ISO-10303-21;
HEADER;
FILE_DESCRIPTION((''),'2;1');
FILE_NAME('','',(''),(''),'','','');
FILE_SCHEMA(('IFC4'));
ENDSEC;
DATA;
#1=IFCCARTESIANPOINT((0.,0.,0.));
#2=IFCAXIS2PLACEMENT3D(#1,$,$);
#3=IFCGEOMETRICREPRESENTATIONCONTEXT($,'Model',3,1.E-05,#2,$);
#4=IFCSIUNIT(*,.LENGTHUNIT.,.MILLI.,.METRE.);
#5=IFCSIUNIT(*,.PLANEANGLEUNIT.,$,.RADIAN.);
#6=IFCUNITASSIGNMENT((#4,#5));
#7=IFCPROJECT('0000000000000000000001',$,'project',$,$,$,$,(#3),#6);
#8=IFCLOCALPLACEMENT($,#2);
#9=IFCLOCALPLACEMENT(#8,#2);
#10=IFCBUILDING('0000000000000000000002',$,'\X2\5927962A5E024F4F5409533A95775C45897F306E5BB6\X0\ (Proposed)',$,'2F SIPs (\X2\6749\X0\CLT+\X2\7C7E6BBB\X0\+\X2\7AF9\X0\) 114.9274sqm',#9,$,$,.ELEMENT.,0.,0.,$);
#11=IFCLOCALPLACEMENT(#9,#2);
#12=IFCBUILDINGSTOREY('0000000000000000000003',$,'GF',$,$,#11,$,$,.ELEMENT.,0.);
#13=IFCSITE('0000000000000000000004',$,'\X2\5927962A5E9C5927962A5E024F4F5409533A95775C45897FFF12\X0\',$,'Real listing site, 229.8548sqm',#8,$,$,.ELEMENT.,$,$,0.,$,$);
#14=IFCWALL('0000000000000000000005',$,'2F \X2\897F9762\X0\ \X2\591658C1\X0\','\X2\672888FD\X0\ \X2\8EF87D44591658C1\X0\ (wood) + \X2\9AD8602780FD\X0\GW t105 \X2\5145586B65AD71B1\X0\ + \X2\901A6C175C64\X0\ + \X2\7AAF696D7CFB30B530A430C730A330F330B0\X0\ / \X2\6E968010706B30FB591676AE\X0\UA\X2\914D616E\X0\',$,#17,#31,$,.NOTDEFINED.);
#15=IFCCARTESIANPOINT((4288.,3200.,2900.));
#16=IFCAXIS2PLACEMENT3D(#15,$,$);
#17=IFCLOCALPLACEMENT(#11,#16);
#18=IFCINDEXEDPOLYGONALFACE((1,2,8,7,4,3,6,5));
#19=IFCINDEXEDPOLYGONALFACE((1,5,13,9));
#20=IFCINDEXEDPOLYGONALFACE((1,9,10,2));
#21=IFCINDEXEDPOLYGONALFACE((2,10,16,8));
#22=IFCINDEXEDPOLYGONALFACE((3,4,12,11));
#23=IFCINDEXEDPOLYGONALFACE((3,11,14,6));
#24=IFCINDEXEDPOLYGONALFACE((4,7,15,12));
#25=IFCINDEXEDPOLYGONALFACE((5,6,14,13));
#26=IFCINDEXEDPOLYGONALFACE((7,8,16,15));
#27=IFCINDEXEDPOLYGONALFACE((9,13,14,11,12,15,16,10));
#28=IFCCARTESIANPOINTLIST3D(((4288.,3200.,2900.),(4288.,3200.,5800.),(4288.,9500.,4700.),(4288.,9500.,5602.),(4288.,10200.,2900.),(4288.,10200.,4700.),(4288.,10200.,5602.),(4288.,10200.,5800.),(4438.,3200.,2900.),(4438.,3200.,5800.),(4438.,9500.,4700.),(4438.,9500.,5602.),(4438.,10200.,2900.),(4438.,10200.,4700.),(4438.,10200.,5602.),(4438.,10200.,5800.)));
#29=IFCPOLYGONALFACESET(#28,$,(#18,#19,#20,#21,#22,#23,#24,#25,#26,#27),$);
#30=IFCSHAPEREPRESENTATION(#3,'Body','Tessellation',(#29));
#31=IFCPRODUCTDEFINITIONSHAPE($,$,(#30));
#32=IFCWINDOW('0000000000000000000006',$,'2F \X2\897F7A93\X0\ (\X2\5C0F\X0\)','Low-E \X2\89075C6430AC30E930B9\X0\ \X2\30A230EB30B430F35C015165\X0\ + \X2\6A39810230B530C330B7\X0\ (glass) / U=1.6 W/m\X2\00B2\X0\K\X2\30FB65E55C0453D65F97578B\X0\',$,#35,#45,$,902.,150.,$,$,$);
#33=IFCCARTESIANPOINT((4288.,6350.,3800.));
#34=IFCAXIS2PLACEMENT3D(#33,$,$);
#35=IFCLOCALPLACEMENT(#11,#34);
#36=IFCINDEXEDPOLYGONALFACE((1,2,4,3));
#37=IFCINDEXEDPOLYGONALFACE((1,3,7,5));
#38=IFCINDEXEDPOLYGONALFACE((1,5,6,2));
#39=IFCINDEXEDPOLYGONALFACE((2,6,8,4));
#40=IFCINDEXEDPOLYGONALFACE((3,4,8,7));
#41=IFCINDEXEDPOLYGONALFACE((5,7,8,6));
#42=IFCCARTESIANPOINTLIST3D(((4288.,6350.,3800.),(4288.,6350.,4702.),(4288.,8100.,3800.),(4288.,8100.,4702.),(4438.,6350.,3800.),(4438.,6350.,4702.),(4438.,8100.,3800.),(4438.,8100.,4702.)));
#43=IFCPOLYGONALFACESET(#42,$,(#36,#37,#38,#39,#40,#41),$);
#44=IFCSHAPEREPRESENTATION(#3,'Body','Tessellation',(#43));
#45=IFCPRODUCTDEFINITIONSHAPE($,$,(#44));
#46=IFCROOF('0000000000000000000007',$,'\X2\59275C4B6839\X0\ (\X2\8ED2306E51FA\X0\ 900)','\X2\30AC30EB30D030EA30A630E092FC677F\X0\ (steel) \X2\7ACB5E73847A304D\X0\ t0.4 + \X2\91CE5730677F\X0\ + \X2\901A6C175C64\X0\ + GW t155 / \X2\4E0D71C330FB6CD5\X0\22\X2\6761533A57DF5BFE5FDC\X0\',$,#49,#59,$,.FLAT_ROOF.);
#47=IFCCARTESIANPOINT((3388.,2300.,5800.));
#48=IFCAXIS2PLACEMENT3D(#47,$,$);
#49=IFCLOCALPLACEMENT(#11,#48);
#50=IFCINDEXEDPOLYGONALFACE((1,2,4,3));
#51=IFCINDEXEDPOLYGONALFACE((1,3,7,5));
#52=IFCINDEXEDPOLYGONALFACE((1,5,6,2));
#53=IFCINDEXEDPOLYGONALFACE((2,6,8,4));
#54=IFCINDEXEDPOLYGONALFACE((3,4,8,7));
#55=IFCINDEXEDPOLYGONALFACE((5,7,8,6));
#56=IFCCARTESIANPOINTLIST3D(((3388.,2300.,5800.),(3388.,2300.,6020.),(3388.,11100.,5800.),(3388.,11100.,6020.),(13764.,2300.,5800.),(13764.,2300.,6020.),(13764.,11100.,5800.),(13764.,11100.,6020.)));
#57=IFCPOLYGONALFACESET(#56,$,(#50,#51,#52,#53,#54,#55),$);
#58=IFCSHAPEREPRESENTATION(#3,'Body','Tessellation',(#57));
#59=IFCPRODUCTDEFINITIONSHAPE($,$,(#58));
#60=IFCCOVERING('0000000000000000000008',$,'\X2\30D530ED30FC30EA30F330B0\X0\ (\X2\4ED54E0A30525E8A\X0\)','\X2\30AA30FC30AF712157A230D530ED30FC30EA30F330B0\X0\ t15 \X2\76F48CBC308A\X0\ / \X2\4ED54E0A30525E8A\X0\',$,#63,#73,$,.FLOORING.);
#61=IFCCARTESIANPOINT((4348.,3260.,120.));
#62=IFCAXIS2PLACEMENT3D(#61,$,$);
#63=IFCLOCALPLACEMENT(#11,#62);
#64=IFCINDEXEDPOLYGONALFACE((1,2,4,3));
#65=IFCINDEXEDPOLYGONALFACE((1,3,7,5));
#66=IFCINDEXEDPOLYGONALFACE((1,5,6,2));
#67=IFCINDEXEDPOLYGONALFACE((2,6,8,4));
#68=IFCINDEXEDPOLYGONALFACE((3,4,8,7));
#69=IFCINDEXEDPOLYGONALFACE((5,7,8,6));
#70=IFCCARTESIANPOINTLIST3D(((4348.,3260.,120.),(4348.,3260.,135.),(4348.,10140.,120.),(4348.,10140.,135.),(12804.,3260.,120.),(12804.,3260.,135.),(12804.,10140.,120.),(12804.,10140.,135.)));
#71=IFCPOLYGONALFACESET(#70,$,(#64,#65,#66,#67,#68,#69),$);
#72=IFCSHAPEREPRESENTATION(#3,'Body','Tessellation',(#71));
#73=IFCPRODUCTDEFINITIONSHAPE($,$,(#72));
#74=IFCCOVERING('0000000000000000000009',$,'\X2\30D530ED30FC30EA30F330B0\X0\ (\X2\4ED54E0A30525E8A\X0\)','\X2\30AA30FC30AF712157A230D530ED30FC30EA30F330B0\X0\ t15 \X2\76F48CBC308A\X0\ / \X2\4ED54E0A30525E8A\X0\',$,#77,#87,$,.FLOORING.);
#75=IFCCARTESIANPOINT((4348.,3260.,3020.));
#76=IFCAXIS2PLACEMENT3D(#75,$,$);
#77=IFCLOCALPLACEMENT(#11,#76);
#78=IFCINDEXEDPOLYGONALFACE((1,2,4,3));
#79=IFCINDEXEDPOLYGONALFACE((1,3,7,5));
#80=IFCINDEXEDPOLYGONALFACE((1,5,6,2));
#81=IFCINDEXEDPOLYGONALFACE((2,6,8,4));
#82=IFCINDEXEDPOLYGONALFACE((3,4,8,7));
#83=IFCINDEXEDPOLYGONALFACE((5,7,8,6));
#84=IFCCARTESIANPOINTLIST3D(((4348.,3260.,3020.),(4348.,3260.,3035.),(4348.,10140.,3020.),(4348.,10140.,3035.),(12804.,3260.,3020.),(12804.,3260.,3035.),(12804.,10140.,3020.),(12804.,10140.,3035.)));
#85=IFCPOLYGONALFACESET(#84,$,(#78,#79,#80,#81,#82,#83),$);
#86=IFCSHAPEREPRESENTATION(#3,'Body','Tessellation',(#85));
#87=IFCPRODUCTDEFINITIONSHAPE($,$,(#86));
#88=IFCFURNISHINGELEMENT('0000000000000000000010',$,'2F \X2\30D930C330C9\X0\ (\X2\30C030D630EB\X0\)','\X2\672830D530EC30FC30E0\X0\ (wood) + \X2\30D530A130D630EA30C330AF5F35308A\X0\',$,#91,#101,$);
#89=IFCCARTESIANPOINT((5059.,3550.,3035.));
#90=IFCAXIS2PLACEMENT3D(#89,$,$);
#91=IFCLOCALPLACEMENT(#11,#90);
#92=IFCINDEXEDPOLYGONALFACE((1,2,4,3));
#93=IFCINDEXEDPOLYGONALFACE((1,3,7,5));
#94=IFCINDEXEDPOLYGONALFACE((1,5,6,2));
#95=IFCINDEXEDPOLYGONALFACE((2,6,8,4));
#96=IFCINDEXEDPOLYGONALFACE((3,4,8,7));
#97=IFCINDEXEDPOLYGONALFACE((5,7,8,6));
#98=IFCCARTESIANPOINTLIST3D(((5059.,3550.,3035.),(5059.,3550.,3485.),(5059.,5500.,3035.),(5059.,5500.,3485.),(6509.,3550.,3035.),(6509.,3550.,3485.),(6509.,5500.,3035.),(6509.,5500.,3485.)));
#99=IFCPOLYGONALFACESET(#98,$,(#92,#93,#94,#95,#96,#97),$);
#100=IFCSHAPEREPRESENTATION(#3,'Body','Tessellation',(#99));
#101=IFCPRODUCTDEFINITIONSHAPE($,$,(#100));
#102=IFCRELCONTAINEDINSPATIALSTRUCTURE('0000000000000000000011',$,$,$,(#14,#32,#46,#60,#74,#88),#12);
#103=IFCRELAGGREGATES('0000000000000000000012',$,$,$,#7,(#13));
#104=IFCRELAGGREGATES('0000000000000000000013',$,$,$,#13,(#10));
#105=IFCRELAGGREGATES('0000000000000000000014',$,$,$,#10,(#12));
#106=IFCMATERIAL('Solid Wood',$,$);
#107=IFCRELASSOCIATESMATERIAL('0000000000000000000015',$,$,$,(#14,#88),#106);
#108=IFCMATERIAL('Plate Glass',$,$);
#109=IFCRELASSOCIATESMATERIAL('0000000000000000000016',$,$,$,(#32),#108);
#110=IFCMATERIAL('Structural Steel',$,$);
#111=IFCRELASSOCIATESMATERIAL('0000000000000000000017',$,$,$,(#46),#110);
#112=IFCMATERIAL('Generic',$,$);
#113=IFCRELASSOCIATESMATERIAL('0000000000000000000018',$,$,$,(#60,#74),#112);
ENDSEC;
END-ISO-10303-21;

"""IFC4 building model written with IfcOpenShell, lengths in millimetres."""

from ifc_helpers import new_model, si_unit, frame, frame_2d, origin, place, context, project, spatial, rectangle, extrude, material, element, fill, save


model = new_model("IFC4")

# Units and contexts
model_context = context("Model", 3, precision=1e-05, world=origin())
ifc_project = project(units=[si_unit("LENGTHUNIT", "METRE", prefix="MILLI"), si_unit("PLANEANGLEUNIT", "RADIAN")], contexts=[model_context])

# Site, building, storey
site_placement = place(None, origin())
site = spatial("IfcSite", under=ifc_project, at=site_placement, Name="大阪府大阪市住吉区長居西２", ObjectType="Real listing site, 229.8548sqm", CompositionType="ELEMENT", RefElevation=0.0)
building_placement = place(site_placement, origin())
building = spatial("IfcBuilding", under=site, at=building_placement, Name="大阪市住吉区長居西の家 (Proposed)", ObjectType="2F SIPs (杉CLT+籾殻+竹) 114.9274sqm", CompositionType="ELEMENT", ElevationOfRefHeight=0.0, ElevationOfTerrain=0.0)
storey_placement = place(building_placement, origin())
storey = spatial("IfcBuildingStorey", under=building, at=storey_placement, Name="GF", CompositionType="ELEMENT", Elevation=0.0)

# Shared definitions
ifc_material_1 = material(Name="Solid Wood")

# Shared definitions
ifc_material_2 = material(Name="Plate Glass")

# Wall, opening, window
wall_1_placement = place(storey_placement, frame((4288.0, 3200.0, 2900.0)))
wall_1 = element("IfcWall", 1, at=wall_1_placement, inside=storey, material=ifc_material_1, Name="2F 西面 外壁", Description="木製 軸組外壁 (wood) + 高性能GW t105 充填断熱 + 通気層 + 窯業系サイディング / 準耐火・外皮UA配慮", PredefinedType="NOTDEFINED", context=model_context, shape_type="SweptSolid", body=[
    extrude(rectangle(XDim=150.0, YDim=7000.0, at=frame_2d((75.0, 3500.0))), frame((4288.0, 3200.0, 2900.0)), (0.0, 0.0, 1.0), 2900.0),
])
opening_1_placement = place(storey_placement, frame((4288.0, 6350.0, 3800.0)))
opening_1 = element("IfcOpeningElement", 2, at=opening_1_placement, cuts=wall_1, PredefinedType="NOTDEFINED", context=model_context, shape_type="SweptSolid", body=[
    extrude(rectangle(XDim=150.0, YDim=1750.0, at=frame_2d((75.0, 875.0))), frame((4288.0, 6350.0, 3800.0)), (0.0, 0.0, 1.0), 902.0),
])
window_1_placement = place(storey_placement, frame((4288.0, 6350.0, 3800.0)))
window_1 = element("IfcWindow", 3, at=window_1_placement, inside=storey, material=ifc_material_2, Name="2F 西窓 (小)", Description="Low-E 複層ガラス アルゴン封入 + 樹脂サッシ (glass) / U=1.6 W/m²K・日射取得型", OverallHeight=902.0, OverallWidth=150.0, context=model_context, shape_type="SweptSolid", body=[
    extrude(rectangle(XDim=150.0, YDim=1750.0, at=frame_2d((75.0, 875.0))), frame((4288.0, 6350.0, 3800.0)), (0.0, 0.0, 1.0), 902.0),
])
fill(opening_1, window_1)

# Roof
ifc_material_3 = material(Name="Structural Steel")
roof_placement = place(storey_placement, frame((3388.0, 2300.0, 5800.0)))
element("IfcRoof", 4, at=roof_placement, inside=storey, material=ifc_material_3, Name="大屋根 (軒の出 900)", Description="ガルバリウム鋼板 (steel) 立平葺き t0.4 + 野地板 + 通気層 + GW t155 / 不燃・法22条区域対応", PredefinedType="FLAT_ROOF", context=model_context, shape_type="SweptSolid", body=[
    extrude(rectangle(XDim=10376.0, YDim=8800.0, at=frame_2d((5188.0, 4400.0))), frame((3388.0, 2300.0, 5800.0)), (0.0, 0.0, 1.0), 220.0),
])

# Coverings
ifc_material_4 = material(Name="Generic")
covering_1_placement = place(storey_placement, frame((4348.0, 3260.0, 120.0)))
element("IfcCovering", 5, at=covering_1_placement, inside=storey, material=ifc_material_4, Name="フローリング (仕上げ床)", Description="オーク無垢フローリング t15 直貼り / 仕上げ床", PredefinedType="FLOORING", context=model_context, shape_type="SweptSolid", body=[
    extrude(rectangle(XDim=8456.0, YDim=6880.0, at=frame_2d((4228.0, 3440.0))), frame((4348.0, 3260.0, 120.0)), (0.0, 0.0, 1.0), 15.0),
])
covering_2_placement = place(storey_placement, frame((4348.0, 3260.0, 3020.0)))
element("IfcCovering", 6, at=covering_2_placement, inside=storey, material=ifc_material_4, Name="フローリング (仕上げ床)", Description="オーク無垢フローリング t15 直貼り / 仕上げ床", PredefinedType="FLOORING", context=model_context, shape_type="SweptSolid", body=[
    extrude(rectangle(XDim=8456.0, YDim=6880.0, at=frame_2d((4228.0, 3440.0))), frame((4348.0, 3260.0, 3020.0)), (0.0, 0.0, 1.0), 15.0),
])

# Furnishing element
furnishing_placement = place(storey_placement, frame((5059.0, 3550.0, 3035.0)))
element("IfcFurnishingElement", 7, at=furnishing_placement, inside=storey, material=ifc_material_1, Name="2F ベッド (ダブル)", Description="木フレーム (wood) + ファブリック張り", context=model_context, shape_type="SweptSolid", body=[
    extrude(rectangle(XDim=1450.0, YDim=1950.0, at=frame_2d((725.0, 975.0))), frame((5059.0, 3550.0, 3035.0)), (0.0, 0.0, 1.0), 450.0),
])

save(model, "model.ifc")
